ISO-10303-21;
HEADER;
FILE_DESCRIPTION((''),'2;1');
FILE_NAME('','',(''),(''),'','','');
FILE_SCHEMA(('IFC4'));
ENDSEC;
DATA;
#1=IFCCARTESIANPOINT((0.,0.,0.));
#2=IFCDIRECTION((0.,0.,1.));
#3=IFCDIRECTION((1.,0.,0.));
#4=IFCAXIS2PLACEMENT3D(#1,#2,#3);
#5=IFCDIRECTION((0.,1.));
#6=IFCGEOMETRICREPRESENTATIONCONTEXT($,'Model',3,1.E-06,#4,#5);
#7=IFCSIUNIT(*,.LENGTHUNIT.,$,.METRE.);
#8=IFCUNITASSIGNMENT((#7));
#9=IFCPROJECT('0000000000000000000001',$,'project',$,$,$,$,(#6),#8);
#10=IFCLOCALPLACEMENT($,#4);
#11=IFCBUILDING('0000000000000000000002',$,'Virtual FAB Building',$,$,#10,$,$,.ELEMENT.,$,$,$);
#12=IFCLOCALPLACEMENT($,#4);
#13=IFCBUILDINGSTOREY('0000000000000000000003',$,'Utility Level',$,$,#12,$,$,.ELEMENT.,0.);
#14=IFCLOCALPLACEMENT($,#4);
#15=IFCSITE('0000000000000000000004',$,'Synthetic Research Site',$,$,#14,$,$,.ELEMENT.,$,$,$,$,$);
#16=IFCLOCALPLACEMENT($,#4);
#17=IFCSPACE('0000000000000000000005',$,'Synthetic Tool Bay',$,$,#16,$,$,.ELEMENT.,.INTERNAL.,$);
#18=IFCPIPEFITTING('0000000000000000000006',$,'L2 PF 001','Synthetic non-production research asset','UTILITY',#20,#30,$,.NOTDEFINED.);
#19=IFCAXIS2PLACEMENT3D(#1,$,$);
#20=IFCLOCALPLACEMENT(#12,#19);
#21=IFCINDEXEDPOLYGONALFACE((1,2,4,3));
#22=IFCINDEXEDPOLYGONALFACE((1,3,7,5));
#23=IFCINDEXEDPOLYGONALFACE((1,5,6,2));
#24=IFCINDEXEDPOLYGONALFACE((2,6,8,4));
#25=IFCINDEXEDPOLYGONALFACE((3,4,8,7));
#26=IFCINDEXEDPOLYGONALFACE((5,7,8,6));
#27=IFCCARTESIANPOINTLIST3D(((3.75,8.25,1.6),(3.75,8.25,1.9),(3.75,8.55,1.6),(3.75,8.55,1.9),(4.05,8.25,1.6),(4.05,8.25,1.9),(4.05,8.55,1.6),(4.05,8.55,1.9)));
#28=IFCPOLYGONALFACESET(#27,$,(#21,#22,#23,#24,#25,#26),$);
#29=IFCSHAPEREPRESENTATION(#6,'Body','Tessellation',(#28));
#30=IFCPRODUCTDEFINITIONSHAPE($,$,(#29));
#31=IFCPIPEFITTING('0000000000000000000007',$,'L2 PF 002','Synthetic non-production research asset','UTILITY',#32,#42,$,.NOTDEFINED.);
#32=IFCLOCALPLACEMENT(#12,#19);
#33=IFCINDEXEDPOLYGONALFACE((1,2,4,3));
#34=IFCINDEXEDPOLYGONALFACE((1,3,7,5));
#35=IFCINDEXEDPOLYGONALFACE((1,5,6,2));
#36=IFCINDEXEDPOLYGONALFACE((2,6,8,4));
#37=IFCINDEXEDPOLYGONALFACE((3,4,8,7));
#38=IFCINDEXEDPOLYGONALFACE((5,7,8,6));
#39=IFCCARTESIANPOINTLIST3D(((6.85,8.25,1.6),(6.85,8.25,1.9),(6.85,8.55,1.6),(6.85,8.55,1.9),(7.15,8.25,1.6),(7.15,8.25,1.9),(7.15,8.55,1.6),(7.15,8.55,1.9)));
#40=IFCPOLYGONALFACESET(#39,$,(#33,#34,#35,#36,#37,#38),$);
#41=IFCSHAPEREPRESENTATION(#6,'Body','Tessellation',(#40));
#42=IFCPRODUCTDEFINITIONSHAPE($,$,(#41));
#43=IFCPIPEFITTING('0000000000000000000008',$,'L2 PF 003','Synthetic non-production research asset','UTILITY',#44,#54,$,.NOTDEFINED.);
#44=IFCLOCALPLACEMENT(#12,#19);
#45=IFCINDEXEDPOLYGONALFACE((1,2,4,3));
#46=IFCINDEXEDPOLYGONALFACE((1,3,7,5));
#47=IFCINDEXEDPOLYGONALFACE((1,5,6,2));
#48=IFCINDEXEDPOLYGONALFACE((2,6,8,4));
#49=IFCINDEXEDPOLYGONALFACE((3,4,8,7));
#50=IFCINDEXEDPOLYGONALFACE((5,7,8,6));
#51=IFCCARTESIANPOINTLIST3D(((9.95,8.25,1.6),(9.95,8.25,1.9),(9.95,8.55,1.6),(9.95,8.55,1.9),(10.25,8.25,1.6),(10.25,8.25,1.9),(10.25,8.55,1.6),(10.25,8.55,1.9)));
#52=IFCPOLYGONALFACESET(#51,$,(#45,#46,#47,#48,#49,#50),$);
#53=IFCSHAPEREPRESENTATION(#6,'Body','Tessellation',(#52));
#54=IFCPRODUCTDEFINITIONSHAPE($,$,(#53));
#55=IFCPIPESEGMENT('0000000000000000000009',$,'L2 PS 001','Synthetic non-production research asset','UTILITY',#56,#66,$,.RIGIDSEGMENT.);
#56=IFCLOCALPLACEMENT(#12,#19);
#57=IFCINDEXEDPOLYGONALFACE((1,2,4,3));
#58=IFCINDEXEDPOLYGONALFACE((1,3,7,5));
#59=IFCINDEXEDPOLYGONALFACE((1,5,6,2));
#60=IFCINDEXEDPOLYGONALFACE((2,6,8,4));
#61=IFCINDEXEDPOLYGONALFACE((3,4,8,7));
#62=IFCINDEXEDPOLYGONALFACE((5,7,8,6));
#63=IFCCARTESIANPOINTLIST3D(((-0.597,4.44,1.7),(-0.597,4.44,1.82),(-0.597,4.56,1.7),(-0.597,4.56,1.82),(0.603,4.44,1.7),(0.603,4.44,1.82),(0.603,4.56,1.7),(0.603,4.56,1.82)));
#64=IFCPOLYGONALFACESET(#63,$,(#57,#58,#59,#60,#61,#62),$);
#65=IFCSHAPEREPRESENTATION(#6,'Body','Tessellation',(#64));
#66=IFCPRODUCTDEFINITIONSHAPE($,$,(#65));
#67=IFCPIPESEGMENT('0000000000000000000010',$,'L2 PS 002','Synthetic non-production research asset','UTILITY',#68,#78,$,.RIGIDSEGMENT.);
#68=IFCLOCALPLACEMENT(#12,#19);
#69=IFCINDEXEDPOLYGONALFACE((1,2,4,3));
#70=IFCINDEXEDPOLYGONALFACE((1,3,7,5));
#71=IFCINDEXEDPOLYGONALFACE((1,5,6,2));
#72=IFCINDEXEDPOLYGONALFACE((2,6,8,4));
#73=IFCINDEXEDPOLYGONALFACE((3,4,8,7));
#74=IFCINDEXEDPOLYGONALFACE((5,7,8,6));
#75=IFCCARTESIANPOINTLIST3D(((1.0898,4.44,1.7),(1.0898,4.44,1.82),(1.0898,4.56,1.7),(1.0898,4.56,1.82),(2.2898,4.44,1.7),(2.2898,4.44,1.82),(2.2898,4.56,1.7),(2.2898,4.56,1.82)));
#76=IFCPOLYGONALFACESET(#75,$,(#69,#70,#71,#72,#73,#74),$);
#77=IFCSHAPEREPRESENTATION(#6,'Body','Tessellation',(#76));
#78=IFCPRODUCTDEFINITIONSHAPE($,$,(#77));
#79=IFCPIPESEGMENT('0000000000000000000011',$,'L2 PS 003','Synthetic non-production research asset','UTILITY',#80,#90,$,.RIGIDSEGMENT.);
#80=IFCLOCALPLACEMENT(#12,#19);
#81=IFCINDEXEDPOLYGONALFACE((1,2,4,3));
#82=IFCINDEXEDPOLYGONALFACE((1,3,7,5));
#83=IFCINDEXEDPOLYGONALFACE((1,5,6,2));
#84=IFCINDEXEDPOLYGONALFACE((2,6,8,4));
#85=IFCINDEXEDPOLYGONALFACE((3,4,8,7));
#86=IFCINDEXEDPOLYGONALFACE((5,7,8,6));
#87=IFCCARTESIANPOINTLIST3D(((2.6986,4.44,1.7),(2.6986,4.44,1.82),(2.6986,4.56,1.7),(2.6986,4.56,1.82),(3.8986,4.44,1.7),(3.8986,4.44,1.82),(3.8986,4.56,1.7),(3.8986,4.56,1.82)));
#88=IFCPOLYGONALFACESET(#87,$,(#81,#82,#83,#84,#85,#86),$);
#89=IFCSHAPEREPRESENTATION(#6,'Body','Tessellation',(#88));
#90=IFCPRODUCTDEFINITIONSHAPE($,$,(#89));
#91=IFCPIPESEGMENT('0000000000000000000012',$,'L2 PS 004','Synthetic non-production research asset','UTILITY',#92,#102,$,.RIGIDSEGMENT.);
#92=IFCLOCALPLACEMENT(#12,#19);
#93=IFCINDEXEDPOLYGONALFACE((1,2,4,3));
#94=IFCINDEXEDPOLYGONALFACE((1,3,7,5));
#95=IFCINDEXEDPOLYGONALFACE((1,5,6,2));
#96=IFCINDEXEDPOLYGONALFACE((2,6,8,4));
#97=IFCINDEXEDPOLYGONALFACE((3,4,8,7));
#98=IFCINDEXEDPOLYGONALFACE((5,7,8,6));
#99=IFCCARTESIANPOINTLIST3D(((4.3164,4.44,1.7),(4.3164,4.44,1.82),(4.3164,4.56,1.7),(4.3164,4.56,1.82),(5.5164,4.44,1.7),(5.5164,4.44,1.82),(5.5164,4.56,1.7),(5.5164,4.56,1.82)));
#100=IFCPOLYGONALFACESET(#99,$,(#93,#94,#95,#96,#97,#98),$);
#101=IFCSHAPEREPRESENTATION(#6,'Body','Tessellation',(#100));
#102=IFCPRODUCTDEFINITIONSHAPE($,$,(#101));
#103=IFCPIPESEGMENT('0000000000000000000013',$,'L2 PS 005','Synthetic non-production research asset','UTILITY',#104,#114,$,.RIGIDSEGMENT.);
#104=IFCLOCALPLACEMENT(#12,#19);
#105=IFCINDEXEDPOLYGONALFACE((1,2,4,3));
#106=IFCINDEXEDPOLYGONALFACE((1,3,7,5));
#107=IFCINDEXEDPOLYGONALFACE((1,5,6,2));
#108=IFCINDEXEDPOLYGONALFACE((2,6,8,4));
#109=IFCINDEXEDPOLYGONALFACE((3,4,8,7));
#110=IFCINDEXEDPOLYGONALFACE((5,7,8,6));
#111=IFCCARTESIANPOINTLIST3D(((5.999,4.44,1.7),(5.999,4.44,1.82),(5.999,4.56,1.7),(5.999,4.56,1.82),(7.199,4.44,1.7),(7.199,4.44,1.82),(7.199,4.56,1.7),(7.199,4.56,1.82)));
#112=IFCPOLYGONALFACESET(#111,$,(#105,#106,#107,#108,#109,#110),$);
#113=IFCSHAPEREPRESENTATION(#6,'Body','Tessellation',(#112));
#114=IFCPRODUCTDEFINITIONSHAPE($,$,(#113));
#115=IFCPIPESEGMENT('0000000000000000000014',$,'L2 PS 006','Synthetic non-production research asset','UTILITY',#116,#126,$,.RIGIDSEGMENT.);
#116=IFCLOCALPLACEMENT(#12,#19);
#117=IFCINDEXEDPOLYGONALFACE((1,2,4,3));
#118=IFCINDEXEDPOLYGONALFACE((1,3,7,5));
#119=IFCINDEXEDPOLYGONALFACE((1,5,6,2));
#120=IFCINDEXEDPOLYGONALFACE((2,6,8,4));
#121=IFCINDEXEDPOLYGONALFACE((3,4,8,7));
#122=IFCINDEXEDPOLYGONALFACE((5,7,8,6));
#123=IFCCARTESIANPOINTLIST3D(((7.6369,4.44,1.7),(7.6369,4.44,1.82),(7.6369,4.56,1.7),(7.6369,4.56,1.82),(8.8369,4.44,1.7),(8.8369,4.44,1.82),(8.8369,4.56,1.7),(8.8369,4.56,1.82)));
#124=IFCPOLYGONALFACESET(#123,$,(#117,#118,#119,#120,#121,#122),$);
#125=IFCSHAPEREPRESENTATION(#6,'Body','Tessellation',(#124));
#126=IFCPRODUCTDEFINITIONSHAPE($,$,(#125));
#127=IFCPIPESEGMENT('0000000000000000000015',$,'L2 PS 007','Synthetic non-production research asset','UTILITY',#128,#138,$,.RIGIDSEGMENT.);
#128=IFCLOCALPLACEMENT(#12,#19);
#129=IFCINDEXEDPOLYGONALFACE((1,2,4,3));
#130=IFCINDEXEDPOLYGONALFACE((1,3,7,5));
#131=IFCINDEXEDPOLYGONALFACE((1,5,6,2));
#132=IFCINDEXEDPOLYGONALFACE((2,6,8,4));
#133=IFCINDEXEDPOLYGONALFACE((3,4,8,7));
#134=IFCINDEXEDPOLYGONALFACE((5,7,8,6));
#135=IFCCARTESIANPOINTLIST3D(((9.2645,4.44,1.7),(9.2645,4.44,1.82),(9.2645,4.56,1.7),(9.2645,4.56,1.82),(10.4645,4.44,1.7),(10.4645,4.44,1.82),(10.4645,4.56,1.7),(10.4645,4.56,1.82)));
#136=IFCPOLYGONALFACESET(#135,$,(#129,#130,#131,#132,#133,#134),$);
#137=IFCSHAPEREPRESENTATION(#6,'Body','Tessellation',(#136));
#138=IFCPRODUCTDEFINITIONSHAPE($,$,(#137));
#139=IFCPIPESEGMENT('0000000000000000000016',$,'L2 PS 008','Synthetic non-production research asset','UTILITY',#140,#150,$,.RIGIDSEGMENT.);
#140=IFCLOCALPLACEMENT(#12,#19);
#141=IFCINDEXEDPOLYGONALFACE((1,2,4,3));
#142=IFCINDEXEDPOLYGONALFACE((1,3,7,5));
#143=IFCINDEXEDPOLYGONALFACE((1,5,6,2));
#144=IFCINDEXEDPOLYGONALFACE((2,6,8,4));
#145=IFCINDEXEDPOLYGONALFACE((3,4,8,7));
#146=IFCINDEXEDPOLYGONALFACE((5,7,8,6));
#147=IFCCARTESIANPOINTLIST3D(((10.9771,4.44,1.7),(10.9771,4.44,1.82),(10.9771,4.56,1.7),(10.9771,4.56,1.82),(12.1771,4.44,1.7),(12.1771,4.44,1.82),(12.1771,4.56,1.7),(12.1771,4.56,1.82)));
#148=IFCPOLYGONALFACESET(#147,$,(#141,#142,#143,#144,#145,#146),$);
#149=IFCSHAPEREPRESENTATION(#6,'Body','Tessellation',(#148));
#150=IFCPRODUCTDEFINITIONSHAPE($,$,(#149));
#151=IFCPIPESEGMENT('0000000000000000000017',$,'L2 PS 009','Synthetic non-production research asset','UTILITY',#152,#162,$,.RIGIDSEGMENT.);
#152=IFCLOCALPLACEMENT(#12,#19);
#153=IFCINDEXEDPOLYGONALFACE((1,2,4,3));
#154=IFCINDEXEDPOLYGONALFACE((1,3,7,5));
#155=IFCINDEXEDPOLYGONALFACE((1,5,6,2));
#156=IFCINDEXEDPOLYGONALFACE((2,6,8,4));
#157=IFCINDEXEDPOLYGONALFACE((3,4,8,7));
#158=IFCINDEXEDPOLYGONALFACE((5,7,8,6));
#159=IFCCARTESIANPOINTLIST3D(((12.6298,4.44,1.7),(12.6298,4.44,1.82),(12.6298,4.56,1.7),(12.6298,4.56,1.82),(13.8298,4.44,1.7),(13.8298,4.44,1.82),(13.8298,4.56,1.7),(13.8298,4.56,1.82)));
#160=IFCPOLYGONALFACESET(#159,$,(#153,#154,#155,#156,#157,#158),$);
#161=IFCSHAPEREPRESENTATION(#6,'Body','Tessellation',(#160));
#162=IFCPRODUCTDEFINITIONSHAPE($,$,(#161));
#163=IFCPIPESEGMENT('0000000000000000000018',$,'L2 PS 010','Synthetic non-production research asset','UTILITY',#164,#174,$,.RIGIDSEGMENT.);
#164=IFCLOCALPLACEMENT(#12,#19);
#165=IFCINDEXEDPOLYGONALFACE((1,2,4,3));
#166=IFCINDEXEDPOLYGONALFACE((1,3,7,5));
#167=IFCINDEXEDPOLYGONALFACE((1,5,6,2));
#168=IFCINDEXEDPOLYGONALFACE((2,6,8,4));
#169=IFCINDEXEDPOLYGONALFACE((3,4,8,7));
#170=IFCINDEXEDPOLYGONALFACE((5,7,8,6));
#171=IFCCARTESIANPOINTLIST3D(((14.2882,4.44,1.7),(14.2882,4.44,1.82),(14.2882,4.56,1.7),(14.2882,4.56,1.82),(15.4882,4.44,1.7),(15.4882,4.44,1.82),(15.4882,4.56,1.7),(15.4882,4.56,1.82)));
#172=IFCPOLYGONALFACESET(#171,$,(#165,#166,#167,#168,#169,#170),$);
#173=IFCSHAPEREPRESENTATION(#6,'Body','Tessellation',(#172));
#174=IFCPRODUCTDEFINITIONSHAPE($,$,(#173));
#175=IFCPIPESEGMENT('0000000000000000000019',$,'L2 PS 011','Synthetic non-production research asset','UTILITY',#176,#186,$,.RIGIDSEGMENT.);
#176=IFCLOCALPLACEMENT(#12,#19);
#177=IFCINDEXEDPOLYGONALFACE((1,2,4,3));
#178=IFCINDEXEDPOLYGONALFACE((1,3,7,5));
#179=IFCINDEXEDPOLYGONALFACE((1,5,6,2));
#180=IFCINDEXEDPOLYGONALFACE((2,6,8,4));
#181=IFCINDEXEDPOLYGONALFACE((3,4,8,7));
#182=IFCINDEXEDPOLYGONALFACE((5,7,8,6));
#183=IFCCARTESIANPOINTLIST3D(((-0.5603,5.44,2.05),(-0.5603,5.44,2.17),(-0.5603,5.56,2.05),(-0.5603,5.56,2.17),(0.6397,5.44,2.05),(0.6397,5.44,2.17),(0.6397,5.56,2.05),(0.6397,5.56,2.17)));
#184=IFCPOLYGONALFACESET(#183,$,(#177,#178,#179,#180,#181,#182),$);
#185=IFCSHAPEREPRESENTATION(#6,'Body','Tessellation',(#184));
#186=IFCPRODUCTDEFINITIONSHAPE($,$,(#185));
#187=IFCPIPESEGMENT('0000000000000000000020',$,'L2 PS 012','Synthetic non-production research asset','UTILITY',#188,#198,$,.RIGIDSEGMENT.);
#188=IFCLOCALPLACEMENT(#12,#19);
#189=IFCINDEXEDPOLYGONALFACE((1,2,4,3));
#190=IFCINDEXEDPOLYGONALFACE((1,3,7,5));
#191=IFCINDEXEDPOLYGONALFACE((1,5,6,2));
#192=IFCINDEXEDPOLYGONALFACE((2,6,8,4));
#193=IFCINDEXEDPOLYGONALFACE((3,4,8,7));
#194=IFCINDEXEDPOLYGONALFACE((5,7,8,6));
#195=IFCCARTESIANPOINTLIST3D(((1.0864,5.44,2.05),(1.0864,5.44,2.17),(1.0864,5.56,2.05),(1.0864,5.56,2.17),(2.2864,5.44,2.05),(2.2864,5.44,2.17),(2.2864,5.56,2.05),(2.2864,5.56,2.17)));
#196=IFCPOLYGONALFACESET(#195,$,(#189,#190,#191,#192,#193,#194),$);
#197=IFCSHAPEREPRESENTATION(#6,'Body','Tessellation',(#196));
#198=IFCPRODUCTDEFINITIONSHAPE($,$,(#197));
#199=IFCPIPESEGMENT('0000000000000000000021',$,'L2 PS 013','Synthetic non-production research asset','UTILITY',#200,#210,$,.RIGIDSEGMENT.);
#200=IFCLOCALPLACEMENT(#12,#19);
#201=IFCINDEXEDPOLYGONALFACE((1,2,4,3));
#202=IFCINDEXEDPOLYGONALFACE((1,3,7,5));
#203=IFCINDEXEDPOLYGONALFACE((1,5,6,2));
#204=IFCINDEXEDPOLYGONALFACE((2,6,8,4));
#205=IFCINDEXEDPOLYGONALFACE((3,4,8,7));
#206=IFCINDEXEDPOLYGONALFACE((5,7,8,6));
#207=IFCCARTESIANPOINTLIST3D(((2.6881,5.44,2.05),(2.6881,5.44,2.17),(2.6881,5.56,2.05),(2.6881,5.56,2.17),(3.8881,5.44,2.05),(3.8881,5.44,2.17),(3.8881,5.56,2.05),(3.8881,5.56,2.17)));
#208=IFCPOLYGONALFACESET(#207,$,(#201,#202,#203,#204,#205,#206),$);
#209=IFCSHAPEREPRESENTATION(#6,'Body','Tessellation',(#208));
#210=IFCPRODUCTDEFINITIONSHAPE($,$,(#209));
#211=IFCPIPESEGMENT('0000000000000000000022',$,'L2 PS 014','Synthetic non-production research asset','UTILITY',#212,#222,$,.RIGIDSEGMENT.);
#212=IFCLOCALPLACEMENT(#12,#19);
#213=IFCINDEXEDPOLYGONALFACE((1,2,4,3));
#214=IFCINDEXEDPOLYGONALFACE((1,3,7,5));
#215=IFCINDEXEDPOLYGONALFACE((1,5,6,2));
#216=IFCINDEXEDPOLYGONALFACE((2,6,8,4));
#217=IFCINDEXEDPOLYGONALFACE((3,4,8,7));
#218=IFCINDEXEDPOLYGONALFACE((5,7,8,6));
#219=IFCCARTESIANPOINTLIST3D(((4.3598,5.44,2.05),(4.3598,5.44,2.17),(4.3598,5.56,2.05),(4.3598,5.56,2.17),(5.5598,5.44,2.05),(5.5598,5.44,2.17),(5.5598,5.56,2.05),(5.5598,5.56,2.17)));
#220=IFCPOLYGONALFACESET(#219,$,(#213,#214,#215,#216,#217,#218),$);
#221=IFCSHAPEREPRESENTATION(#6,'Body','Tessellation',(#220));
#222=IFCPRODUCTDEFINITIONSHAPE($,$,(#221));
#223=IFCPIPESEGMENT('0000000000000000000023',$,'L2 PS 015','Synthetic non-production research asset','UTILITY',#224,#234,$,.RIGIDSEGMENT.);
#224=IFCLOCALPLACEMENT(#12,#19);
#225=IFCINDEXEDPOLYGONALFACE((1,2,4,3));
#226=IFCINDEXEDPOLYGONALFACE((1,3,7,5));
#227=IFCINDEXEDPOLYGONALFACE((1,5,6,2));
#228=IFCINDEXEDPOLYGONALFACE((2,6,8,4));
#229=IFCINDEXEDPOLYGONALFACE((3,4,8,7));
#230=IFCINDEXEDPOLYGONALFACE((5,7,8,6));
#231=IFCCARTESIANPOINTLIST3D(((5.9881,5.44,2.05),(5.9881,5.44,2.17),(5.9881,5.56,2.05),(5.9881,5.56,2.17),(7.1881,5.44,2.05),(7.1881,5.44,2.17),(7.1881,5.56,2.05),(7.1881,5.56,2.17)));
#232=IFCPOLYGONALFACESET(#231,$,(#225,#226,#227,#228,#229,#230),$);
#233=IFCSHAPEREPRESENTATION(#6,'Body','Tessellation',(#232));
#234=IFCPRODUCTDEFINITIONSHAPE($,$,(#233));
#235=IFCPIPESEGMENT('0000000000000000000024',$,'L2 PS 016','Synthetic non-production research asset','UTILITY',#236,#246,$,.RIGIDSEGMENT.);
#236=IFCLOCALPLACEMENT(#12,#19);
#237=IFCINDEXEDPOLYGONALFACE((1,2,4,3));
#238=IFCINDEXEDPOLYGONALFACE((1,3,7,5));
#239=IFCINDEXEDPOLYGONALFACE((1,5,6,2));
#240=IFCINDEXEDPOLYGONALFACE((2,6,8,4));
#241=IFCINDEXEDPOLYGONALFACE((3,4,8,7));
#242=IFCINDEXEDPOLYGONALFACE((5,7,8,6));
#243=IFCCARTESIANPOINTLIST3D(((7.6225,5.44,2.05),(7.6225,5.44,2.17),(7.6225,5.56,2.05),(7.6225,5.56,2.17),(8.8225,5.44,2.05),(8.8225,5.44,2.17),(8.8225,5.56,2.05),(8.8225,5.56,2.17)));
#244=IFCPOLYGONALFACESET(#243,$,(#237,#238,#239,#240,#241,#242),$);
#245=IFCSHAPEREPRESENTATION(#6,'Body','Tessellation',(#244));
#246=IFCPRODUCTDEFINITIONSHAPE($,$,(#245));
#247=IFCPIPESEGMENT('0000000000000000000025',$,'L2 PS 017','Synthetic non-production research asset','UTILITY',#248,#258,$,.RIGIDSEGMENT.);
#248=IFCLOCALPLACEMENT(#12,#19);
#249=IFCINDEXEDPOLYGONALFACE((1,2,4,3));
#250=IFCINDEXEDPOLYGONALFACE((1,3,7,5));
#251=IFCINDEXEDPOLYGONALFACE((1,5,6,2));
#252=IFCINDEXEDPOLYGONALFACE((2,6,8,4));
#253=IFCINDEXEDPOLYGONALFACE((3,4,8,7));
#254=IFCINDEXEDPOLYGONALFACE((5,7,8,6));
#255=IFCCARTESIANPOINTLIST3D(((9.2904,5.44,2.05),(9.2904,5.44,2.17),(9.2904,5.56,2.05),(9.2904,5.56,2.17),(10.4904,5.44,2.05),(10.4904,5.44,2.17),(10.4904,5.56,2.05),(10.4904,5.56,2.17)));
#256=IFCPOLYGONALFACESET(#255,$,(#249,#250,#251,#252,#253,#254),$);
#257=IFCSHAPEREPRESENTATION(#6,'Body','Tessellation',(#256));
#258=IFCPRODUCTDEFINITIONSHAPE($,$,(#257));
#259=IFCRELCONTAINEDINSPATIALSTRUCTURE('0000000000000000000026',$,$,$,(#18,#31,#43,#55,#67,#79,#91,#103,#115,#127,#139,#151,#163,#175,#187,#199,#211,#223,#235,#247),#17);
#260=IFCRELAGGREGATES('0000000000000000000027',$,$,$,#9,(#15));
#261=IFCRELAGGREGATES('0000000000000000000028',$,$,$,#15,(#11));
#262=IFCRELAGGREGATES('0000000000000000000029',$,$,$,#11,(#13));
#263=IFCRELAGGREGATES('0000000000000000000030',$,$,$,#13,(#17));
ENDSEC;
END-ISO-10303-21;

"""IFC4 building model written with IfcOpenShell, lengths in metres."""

from ifc_helpers import new_model, si_unit, direction, frame, origin_with_axes, origin_2d_with_axis, place, context, project, spatial, rectangle, extrude, element, save


model = new_model("IFC4")

# Units and contexts
model_context = context("Model", 3, precision=1e-06, world=origin_with_axes(), true_north=direction((0.0, 1.0)))
ifc_project = project(units=[si_unit("LENGTHUNIT", "METRE")], contexts=[model_context])

# Site, building, storey, space
site_placement = place(None, origin_with_axes())
site = spatial("IfcSite", under=ifc_project, at=site_placement, Name="Synthetic Research Site", CompositionType="ELEMENT")
building_placement = place(None, origin_with_axes())
building = spatial("IfcBuilding", under=site, at=building_placement, Name="Virtual FAB Building", CompositionType="ELEMENT")
storey_placement = place(None, origin_with_axes())
storey = spatial("IfcBuildingStorey", under=building, at=storey_placement, Name="Utility Level", CompositionType="ELEMENT", Elevation=0.0)
space_placement = place(None, origin_with_axes())
space = spatial("IfcSpace", under=storey, at=space_placement, Name="Synthetic Tool Bay", CompositionType="ELEMENT", PredefinedType="INTERNAL")

# Pipe fittings
for number, where, z_axis, x_axis, name in (
    (1, (3.9, 8.4, 1.6), (0.0, 0.0, 1.0), (1.0, 0.0, 0.0), "L2 PF 001"),
    (2, (7.0, 8.4, 1.6), (0.0, 0.0, 1.0), (1.0, 0.0, 0.0), "L2 PF 002"),
    (3, (10.1, 8.4, 1.6), (0.0, 0.0, 1.0), (1.0, 0.0, 0.0), "L2 PF 003"),
):
    element("IfcPipeFitting", number, at=place(None, frame(where, z_axis=z_axis, x_axis=x_axis)), inside=space, Name=name, Description="Synthetic non-production research asset", ObjectType="UTILITY", PredefinedType="NOTDEFINED", context=model_context, shape_type="SweptSolid", body=[
        extrude(rectangle(XDim=0.3, YDim=0.3, at=origin_2d_with_axis()), origin_with_axes(), (0.0, 0.0, 1.0), 0.3),
    ])

# Pipe segments
for number, where, z_axis, x_axis, name in (
    (4, (0.003, 4.5, 1.7), (0.0, 0.0, 1.0), (1.0, 0.0, 0.0), "L2 PS 001"),
    (5, (1.6898, 4.5, 1.7), (0.0, 0.0, 1.0), (1.0, 0.0, 0.0), "L2 PS 002"),
    (6, (3.2986, 4.5, 1.7), (0.0, 0.0, 1.0), (1.0, 0.0, 0.0), "L2 PS 003"),
    (7, (4.9164, 4.5, 1.7), (0.0, 0.0, 1.0), (1.0, 0.0, 0.0), "L2 PS 004"),
    (8, (6.599, 4.5, 1.7), (0.0, 0.0, 1.0), (1.0, 0.0, 0.0), "L2 PS 005"),
    (9, (8.2369, 4.5, 1.7), (0.0, 0.0, 1.0), (1.0, 0.0, 0.0), "L2 PS 006"),
    (10, (9.8645, 4.5, 1.7), (0.0, 0.0, 1.0), (1.0, 0.0, 0.0), "L2 PS 007"),
    (11, (11.5771, 4.5, 1.7), (0.0, 0.0, 1.0), (1.0, 0.0, 0.0), "L2 PS 008"),
    (12, (13.2298, 4.5, 1.7), (0.0, 0.0, 1.0), (1.0, 0.0, 0.0), "L2 PS 009"),
    (13, (14.8882, 4.5, 1.7), (0.0, 0.0, 1.0), (1.0, 0.0, 0.0), "L2 PS 010"),
    (14, (0.0397, 5.5, 2.05), (0.0, 0.0, 1.0), (1.0, 0.0, 0.0), "L2 PS 011"),
    (15, (1.6864, 5.5, 2.05), (0.0, 0.0, 1.0), (1.0, 0.0, 0.0), "L2 PS 012"),
    (16, (3.2881, 5.5, 2.05), (0.0, 0.0, 1.0), (1.0, 0.0, 0.0), "L2 PS 013"),
    (17, (4.9598, 5.5, 2.05), (0.0, 0.0, 1.0), (1.0, 0.0, 0.0), "L2 PS 014"),
    (18, (6.5881, 5.5, 2.05), (0.0, 0.0, 1.0), (1.0, 0.0, 0.0), "L2 PS 015"),
    (19, (8.2225, 5.5, 2.05), (0.0, 0.0, 1.0), (1.0, 0.0, 0.0), "L2 PS 016"),
    (20, (9.8904, 5.5, 2.05), (0.0, 0.0, 1.0), (1.0, 0.0, 0.0), "L2 PS 017"),
):
    element("IfcPipeSegment", number, at=place(None, frame(where, z_axis=z_axis, x_axis=x_axis)), inside=space, Name=name, Description="Synthetic non-production research asset", ObjectType="UTILITY", PredefinedType="RIGIDSEGMENT", context=model_context, shape_type="SweptSolid", body=[
        extrude(rectangle(XDim=1.2, YDim=0.12, at=origin_2d_with_axis()), origin_with_axes(), (0.0, 0.0, 1.0), 0.12),
    ])

save(model, "model.ifc")
